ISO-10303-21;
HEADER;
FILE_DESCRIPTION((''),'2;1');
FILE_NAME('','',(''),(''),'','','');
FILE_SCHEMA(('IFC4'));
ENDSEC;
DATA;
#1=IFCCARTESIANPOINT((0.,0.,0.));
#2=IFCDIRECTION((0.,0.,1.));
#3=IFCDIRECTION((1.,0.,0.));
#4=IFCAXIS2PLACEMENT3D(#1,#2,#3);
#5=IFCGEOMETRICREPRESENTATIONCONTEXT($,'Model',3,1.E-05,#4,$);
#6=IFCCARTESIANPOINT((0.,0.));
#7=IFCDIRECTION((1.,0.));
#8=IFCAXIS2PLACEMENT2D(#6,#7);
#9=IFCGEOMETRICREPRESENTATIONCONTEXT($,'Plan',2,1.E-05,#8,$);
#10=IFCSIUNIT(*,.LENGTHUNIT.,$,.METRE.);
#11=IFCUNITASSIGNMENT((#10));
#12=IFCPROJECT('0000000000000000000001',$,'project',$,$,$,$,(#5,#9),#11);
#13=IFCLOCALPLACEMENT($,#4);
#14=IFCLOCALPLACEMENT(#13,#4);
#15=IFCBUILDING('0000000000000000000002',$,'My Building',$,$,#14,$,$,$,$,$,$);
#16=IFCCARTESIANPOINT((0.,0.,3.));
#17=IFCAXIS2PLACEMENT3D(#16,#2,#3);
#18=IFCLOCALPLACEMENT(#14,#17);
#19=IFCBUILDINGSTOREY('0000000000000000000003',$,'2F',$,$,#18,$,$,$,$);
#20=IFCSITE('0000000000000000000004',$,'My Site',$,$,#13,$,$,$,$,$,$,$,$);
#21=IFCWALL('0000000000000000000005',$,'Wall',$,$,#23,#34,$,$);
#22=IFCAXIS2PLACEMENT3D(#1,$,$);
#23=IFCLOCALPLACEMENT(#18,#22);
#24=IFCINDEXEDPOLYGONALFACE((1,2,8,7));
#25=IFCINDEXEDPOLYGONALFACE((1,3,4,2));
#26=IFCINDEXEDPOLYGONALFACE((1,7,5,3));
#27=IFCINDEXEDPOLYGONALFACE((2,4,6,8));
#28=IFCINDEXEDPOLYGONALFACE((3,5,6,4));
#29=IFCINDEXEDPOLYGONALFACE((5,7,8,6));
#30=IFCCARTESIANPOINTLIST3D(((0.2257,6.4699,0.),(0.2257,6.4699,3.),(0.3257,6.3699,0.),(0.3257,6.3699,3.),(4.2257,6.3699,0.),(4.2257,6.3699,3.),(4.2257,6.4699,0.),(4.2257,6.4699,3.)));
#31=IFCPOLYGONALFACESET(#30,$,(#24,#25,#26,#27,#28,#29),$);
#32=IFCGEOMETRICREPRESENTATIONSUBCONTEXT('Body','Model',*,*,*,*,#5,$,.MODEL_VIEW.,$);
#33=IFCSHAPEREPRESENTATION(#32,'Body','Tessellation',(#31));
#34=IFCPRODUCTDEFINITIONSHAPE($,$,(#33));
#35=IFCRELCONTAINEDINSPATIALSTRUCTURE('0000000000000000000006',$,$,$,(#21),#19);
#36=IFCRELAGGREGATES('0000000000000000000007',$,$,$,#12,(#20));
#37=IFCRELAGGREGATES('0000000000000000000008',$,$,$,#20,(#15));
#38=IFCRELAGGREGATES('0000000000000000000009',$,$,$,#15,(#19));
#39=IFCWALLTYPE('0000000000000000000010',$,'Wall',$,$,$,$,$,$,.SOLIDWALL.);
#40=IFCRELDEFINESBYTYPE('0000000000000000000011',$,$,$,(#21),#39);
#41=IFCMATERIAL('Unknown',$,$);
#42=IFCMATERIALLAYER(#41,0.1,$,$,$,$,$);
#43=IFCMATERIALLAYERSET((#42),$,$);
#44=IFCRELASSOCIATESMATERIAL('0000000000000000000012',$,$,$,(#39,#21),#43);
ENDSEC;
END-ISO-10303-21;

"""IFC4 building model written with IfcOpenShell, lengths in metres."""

from ifc_helpers import new_model, si_unit, frame, origin_with_axes, origin_2d_with_axis, place, context, subcontext, project, spatial, line, indexed_curve, outline, extrude, material, layer, layer_set, layer_usage, type_object, element, save


model = new_model("IFC4")

# Units and contexts
model_context = context("Model", 3, precision=1e-05, world=origin_with_axes())
plan_context = context("Plan", 2, precision=1e-05, world=origin_2d_with_axis())
body_context_1 = subcontext(model_context, "Body", "Model", "MODEL_VIEW")
ifc_project = project(units=[si_unit("LENGTHUNIT", "METRE")], contexts=[model_context, plan_context])

# Site, building, storey
site_placement = place(None, origin_with_axes())
site = spatial("IfcSite", under=ifc_project, at=site_placement, Name="My Site")
building_placement = place(site_placement, origin_with_axes())
building = spatial("IfcBuilding", under=site, at=building_placement, Name="My Building")
storey_placement = place(building_placement, frame((0.0, 0.0, 3.0), z_axis=(0.0, 0.0, 1.0), x_axis=(1.0, 0.0, 0.0)))
storey = spatial("IfcBuildingStorey", under=building, at=storey_placement, Name="2F")

# Wall
ifc_material = material(Name="Unknown")
ifc_layer = layer(ifc_material, 0.1)
ifc_layer_set = layer_set([ifc_layer])
ifc_layer_usage_1 = layer_usage(ifc_layer_set, "AXIS2", "POSITIVE", 0.0)
wall_type = type_object("IfcWallType", Name="Wall", PredefinedType="SOLIDWALL", material=ifc_layer_set)
wall_1_placement = place(storey_placement, frame((4.2257, 6.4699, 0.0), z_axis=(0.0, 0.0, 1.0), x_axis=(-1.0, 0.0, 0.0)))
element("IfcWall", 1, at=wall_1_placement, inside=storey, type_object=wall_type, material=ifc_layer_usage_1, Name="Wall", context=body_context_1, shape_type="SweptSolid", body=[
    extrude(outline(indexed_curve([(0.0, 0.0), (0.0, 0.1), (3.9, 0.1), (4.0, 0.0)], segments=[line(1, 2, 3, 4, 1)])), origin_with_axes(), (0.0, 0.0, 1.0), 3.0),
])

save(model, "model.ifc")
